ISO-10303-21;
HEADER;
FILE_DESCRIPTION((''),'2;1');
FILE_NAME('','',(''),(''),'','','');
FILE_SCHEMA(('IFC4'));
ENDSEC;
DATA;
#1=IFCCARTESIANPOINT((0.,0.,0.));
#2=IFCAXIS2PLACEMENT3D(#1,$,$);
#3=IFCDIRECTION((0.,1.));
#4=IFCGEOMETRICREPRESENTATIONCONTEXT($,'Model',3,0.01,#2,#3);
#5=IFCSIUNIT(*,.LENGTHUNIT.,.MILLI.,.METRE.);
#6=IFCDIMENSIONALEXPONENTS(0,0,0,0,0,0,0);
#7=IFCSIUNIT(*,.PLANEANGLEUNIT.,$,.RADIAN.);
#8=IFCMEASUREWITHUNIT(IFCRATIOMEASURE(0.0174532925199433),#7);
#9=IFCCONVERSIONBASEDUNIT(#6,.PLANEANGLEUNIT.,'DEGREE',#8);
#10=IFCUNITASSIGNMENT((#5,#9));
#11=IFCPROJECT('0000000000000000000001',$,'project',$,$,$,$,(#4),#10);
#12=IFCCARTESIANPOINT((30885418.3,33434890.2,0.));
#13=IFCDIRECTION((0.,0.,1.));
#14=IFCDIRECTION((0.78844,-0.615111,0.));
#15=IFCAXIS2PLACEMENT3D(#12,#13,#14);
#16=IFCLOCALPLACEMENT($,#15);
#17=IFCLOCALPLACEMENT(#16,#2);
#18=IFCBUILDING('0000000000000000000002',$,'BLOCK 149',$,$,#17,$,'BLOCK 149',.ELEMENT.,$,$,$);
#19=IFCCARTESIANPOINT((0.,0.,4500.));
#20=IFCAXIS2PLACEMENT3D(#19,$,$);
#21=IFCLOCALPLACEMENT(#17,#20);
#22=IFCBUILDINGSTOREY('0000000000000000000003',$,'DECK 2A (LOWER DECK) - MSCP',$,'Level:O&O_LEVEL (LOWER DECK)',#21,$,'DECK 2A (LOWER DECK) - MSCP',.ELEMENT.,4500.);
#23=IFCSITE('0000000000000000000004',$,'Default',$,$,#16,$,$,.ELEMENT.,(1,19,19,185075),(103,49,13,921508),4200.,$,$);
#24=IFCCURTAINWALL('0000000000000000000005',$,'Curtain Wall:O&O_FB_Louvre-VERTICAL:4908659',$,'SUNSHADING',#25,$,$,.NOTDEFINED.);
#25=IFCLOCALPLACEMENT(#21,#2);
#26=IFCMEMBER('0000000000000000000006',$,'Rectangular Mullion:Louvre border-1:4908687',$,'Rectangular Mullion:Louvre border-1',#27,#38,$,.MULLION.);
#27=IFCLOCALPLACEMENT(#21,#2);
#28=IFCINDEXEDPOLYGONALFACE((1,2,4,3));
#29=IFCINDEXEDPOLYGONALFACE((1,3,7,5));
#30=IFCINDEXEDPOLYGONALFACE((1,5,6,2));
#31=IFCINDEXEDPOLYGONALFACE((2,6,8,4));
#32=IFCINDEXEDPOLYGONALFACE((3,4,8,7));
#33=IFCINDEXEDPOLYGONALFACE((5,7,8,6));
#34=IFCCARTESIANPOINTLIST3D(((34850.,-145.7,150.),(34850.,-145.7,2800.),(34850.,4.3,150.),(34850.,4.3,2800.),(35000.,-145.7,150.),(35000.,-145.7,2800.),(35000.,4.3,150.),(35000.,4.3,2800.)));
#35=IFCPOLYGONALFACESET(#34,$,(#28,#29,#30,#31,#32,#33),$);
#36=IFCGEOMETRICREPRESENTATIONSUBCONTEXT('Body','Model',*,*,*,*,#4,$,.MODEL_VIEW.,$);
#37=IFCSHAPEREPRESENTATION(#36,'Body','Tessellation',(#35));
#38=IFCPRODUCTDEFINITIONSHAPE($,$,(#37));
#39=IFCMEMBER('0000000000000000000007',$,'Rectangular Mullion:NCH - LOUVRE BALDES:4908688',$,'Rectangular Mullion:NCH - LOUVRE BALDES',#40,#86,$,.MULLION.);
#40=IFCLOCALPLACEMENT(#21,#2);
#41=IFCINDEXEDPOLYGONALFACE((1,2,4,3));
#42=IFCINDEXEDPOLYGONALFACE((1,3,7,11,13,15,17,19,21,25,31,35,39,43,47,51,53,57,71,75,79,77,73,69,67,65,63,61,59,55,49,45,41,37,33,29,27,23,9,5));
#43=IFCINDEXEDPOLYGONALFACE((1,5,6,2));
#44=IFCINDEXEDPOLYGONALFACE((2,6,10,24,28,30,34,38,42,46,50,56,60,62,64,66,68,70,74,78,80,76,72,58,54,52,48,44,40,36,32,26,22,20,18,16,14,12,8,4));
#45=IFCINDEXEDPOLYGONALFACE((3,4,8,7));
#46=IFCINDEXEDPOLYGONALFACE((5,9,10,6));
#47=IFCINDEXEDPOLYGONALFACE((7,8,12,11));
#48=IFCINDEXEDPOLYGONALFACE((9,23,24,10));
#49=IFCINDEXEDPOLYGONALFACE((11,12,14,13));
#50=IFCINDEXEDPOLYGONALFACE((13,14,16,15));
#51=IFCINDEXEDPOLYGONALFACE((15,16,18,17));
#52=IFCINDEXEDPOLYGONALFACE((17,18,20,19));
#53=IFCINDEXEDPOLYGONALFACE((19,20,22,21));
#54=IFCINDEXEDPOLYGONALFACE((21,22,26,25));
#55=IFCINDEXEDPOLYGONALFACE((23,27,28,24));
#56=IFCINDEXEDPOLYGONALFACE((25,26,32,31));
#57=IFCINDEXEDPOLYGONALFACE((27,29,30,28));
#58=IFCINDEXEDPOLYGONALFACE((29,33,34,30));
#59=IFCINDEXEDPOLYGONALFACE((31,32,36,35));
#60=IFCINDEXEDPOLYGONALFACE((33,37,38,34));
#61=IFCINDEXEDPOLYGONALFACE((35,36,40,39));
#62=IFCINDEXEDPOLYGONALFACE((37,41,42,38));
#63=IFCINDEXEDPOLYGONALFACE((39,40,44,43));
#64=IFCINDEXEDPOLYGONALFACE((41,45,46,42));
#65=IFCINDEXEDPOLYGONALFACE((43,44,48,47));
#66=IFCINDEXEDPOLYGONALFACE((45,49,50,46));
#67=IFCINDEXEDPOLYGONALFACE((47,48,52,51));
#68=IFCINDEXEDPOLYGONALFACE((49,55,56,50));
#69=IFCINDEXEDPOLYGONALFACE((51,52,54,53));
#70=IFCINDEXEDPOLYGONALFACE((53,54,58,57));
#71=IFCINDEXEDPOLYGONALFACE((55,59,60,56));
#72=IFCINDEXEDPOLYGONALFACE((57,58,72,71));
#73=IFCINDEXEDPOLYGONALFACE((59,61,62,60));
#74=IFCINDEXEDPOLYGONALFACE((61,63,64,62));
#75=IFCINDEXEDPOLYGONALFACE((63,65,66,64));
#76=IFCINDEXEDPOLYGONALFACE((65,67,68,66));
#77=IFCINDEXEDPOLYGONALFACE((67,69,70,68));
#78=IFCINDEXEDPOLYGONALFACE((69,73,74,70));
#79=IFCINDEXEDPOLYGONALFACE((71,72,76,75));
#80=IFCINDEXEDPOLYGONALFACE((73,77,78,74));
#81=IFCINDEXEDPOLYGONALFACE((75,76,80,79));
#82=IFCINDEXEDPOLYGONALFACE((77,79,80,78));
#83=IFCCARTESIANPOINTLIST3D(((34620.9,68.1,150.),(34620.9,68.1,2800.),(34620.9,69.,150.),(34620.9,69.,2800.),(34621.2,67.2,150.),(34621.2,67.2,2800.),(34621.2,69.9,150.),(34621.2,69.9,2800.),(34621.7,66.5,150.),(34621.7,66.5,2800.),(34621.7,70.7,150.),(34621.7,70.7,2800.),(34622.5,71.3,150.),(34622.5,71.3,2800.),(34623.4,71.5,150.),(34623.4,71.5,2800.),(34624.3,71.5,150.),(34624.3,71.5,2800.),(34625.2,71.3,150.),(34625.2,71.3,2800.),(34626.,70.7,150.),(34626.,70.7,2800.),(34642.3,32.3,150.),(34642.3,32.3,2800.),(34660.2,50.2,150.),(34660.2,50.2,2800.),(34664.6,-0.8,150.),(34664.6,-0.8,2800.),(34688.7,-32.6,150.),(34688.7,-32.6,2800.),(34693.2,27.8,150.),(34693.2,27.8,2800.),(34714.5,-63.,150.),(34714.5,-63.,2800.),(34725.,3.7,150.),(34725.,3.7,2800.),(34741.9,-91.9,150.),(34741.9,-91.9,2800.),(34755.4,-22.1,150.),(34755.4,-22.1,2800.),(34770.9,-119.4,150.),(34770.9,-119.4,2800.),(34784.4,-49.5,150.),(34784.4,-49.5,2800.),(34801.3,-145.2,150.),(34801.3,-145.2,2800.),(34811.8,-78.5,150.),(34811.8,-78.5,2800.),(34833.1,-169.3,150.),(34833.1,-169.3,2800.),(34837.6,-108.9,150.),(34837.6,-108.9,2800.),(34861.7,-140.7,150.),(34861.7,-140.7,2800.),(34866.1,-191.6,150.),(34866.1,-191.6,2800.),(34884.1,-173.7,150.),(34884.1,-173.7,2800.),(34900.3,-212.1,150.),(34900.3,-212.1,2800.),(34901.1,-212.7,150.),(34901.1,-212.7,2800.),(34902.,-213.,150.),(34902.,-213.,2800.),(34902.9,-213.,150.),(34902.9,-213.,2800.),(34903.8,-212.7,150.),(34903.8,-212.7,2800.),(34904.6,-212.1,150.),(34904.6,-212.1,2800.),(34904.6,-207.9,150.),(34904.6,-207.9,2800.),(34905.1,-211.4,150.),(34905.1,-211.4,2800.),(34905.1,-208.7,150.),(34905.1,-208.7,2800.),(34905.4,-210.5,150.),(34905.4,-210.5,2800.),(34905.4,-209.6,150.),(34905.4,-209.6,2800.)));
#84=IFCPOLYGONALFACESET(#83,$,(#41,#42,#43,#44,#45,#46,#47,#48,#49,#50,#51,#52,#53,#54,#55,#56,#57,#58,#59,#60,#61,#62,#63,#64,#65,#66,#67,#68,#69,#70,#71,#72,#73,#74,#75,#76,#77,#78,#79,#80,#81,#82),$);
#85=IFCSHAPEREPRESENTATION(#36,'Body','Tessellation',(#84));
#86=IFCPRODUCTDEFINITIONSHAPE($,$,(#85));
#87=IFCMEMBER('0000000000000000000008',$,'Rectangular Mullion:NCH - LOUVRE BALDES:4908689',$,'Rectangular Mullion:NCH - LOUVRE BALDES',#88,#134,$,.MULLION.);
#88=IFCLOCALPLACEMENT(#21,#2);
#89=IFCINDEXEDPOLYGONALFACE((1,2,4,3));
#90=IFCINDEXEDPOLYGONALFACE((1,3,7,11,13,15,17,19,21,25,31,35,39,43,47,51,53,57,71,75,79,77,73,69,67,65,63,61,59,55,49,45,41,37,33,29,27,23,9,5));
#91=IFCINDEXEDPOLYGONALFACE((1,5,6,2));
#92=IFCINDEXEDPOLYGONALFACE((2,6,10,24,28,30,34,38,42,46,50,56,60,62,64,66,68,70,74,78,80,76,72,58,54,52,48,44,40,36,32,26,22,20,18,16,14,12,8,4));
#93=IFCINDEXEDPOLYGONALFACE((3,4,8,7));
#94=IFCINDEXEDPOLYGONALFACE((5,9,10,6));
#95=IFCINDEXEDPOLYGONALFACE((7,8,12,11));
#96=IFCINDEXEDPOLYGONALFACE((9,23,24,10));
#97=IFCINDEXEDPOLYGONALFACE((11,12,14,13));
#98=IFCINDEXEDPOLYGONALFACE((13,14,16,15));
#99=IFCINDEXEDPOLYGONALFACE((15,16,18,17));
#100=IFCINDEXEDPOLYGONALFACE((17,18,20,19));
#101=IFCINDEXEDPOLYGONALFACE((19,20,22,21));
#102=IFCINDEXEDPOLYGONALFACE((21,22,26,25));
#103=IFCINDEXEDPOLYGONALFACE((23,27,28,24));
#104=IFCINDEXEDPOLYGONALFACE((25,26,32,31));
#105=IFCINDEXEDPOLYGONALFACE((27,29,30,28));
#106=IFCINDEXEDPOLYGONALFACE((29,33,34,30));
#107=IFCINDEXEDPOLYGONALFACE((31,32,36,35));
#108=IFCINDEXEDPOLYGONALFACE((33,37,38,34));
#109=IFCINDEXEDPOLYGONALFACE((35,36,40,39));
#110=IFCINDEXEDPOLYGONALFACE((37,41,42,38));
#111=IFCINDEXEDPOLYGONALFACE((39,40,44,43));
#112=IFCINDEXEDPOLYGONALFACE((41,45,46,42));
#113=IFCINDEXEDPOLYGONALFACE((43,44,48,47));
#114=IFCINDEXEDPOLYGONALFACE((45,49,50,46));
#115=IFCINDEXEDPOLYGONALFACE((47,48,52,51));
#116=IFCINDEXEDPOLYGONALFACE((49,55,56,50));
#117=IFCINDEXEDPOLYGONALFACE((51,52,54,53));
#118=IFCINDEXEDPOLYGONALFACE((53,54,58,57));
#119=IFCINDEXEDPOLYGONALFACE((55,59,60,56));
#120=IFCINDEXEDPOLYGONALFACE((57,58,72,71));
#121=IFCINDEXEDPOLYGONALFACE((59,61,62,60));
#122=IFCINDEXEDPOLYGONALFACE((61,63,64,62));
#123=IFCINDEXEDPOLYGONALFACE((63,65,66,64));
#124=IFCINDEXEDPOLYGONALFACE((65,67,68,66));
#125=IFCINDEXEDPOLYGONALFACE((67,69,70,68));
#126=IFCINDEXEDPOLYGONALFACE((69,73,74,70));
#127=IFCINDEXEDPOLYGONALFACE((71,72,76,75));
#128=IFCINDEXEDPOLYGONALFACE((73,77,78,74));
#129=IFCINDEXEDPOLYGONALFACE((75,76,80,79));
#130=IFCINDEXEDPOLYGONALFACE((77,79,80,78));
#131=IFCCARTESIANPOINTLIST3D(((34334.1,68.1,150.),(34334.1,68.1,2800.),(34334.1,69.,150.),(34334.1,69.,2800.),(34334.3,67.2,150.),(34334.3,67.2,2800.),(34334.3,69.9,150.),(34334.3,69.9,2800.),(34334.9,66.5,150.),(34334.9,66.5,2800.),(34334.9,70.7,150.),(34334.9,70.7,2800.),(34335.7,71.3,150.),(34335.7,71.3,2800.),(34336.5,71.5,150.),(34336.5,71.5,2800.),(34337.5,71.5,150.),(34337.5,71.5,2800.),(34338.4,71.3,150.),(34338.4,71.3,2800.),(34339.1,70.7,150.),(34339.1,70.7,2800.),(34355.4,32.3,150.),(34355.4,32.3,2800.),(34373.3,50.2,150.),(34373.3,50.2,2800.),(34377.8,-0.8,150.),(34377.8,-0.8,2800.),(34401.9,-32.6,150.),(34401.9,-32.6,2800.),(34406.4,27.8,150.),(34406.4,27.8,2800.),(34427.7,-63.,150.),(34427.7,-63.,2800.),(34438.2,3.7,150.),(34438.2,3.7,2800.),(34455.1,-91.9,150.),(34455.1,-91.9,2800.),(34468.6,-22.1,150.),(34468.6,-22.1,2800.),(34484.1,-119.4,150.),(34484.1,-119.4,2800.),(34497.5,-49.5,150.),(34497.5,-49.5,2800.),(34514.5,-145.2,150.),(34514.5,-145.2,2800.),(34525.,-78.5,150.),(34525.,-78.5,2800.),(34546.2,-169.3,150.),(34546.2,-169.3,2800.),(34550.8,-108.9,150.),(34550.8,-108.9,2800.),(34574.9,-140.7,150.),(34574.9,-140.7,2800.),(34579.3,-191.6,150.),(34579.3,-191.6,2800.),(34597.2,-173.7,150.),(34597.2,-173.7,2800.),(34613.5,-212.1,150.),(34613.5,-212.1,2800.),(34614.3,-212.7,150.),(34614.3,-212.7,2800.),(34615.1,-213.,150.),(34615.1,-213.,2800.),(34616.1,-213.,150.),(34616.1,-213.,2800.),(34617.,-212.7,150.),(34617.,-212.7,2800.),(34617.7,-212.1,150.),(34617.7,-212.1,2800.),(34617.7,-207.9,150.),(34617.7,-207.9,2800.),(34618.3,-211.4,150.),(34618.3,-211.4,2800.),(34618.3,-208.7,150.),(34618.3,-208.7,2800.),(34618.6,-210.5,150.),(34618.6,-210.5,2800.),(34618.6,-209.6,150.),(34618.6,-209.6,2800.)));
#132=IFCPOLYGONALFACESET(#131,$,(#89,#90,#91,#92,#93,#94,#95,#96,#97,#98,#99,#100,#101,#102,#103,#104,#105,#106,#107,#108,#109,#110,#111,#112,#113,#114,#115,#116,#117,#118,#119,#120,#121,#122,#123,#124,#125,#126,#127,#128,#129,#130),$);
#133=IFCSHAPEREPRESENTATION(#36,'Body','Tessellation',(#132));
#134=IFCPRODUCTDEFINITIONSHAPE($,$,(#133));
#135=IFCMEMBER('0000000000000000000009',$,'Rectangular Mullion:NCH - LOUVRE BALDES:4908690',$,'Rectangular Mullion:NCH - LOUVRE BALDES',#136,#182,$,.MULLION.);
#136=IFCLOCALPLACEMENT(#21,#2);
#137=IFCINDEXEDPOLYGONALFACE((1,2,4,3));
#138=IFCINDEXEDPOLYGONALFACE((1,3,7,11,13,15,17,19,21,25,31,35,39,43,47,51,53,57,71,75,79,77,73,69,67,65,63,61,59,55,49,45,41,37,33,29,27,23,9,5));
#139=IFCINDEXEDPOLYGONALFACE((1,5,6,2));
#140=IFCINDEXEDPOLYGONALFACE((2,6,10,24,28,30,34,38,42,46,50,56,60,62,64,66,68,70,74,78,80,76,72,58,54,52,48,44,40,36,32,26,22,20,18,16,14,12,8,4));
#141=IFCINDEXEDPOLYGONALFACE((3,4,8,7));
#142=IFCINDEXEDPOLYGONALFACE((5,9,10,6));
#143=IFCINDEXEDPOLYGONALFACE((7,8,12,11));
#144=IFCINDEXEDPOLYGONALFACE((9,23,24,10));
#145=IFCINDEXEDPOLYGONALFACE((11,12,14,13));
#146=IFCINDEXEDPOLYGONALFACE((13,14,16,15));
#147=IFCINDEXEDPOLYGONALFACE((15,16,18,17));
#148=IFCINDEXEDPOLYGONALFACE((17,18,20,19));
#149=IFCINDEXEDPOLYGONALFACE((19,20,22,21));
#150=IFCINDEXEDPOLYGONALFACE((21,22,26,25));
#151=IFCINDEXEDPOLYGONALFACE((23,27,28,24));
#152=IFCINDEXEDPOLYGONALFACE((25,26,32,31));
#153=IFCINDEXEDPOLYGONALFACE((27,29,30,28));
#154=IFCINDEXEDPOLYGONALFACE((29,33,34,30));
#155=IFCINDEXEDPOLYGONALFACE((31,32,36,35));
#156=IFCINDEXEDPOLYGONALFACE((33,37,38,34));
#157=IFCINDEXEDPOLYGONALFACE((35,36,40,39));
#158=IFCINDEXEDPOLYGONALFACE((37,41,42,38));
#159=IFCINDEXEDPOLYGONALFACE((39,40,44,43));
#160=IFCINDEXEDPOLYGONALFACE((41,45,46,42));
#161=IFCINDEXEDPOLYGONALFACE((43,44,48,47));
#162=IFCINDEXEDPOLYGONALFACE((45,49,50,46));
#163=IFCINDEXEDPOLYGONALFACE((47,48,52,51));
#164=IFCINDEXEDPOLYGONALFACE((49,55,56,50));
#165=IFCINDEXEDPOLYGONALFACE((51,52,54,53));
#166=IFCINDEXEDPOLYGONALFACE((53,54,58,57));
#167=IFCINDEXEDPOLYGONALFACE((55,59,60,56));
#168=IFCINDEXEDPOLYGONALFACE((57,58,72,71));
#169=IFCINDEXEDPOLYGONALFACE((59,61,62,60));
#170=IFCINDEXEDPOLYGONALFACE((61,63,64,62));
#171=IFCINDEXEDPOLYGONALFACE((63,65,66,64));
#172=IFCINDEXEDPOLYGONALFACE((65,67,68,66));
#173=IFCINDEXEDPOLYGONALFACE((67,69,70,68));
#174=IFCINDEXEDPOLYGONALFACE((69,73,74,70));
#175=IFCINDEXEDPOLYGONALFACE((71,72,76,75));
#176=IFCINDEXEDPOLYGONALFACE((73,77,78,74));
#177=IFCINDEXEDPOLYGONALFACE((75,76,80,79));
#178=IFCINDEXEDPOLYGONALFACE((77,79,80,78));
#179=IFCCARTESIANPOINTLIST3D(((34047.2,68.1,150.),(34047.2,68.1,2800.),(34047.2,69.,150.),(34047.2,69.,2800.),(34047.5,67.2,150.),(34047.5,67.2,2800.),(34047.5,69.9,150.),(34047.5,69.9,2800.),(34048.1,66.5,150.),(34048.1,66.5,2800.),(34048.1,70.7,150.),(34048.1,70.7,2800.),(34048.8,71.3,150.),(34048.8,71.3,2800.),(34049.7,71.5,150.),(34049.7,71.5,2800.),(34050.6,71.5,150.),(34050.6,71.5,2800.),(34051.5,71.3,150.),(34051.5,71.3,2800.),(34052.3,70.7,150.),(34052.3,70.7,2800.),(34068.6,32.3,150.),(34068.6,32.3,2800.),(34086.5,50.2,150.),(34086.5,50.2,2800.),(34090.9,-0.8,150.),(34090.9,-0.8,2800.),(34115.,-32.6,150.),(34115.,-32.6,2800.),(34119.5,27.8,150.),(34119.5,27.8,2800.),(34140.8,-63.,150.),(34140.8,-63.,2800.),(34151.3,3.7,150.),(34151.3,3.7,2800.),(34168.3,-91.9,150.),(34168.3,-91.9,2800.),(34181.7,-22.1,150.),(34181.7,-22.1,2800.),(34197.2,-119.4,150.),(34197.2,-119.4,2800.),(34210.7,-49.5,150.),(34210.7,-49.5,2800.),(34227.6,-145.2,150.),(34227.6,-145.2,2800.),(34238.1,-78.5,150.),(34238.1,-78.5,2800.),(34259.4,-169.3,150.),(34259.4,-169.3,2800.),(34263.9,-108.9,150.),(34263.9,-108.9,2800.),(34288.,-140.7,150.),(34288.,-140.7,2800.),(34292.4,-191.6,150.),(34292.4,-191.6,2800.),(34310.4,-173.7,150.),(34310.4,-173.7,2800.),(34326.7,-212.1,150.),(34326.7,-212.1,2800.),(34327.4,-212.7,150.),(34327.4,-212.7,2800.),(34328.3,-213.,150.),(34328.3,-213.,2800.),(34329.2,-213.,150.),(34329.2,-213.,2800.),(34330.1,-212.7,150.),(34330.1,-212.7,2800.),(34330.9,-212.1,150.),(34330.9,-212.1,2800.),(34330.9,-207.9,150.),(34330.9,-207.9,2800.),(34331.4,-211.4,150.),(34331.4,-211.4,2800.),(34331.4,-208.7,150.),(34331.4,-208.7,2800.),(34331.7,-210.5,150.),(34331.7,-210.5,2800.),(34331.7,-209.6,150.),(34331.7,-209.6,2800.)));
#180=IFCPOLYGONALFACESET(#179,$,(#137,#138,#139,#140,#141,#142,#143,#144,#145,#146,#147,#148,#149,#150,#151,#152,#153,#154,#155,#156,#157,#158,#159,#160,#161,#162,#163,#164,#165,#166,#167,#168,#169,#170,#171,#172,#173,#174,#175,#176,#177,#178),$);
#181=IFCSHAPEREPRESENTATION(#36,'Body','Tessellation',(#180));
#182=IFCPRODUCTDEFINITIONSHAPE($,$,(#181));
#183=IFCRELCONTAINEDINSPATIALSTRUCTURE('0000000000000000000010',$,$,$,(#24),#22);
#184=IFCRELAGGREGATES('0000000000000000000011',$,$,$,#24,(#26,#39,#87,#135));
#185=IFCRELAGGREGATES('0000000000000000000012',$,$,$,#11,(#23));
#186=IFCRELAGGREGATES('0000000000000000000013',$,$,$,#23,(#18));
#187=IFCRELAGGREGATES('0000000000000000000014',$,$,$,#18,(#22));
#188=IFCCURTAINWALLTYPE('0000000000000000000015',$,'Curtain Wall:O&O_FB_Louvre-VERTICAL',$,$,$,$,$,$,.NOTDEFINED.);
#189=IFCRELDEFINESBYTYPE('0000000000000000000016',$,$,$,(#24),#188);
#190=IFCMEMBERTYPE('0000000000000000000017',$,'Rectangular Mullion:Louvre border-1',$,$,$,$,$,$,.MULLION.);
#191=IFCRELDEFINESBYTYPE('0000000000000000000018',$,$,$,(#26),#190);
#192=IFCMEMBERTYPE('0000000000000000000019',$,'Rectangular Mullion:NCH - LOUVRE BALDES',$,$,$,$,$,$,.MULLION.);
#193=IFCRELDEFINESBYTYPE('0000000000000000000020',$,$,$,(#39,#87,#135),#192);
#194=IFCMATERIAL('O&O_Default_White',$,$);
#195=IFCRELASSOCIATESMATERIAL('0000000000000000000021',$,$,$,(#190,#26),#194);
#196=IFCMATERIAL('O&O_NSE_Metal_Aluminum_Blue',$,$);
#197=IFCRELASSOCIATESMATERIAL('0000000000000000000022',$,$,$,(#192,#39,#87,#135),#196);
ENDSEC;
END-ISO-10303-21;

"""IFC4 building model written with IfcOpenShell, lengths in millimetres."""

from ifc_helpers import new_model, entity, si_unit, converted_unit, direction, frame, origin, place, context, subcontext, project, spatial, indexed_curve, outline, extrude, source, transform, mapped, material, type_object, type_shapes, element, aggregate, save


model = new_model("IFC4")

# Units and contexts
model_context = context("Model", 3, precision=0.01, world=origin(), true_north=direction((0.0, 1.0)))
body_context = subcontext(model_context, "Body", "Model", "MODEL_VIEW")
ifc_project = project(units=[si_unit("LENGTHUNIT", "METRE", prefix="MILLI"), converted_unit("PLANEANGLEUNIT", "DEGREE", entity("IfcRatioMeasure", 0.0174532925199433), si_unit("PLANEANGLEUNIT", "RADIAN"), dimensions=[0, 0, 0, 0, 0, 0, 0])], contexts=[model_context])

# Site, building, storey
site_placement = place(None, frame((30885418.3, 33434890.2, 0.0), z_axis=(0.0, 0.0, 1.0), x_axis=(0.78844, -0.615111, 0.0)))
site = spatial("IfcSite", under=ifc_project, at=site_placement, Name="Default", CompositionType="ELEMENT", RefLatitude=(1, 19, 19, 185075), RefLongitude=(103, 49, 13, 921508), RefElevation=4200.0)
building_placement = place(site_placement, origin())
building = spatial("IfcBuilding", under=site, at=building_placement, Name="BLOCK 149", LongName="BLOCK 149", CompositionType="ELEMENT")
storey_placement = place(building_placement, frame((0.0, 0.0, 4500.0)))
storey = spatial("IfcBuildingStorey", under=building, at=storey_placement, Name="DECK 2A (LOWER DECK) - MSCP", ObjectType="Level:O&O_LEVEL (LOWER DECK)", LongName="DECK 2A (LOWER DECK) - MSCP", CompositionType="ELEMENT", Elevation=4500.0)

# Curtain wall, members
curtain_wall_type = type_object("IfcCurtainWallType", Name="Curtain Wall:O&O_FB_Louvre-VERTICAL", PredefinedType="NOTDEFINED")
curtain_wall_placement = place(storey_placement, frame((0.0, 0.0, -4500.0)))
curtain_wall = element("IfcCurtainWall", 1, at=curtain_wall_placement, inside=storey, type_object=curtain_wall_type, Name="Curtain Wall:O&O_FB_Louvre-VERTICAL:4908659", ObjectType="SUNSHADING", PredefinedType="NOTDEFINED")
ifc_material_1 = material(Name="O&O_Default_White")
placement = place(building_placement, origin())
member_type_1 = type_object("IfcMemberType", Name="Rectangular Mullion:Louvre border-1", PredefinedType="MULLION", material=ifc_material_1)
shared_shape_1 = source(origin(), body_context, "Body", "SweptSolid", [
    extrude(outline(indexed_curve([(-75.0, -75.0), (75.0, -75.0), (75.0, 75.0), (-75.0, 75.0), (-75.0, -75.0)], self_intersect=False)), frame((-75.0, 0.0, -2650.0), z_axis=(0.0, 0.0, 1.0), x_axis=(0.0, -1.0, 0.0)), (0.0, 0.0, 1.0), 2650.0),
])
type_shapes(member_type_1, [shared_shape_1])
member_1_placement = place(placement, frame((35000.0, -70.7, 7300.0)))
member_1 = element("IfcMember", 2, at=member_1_placement, type_object=member_type_1, material=ifc_material_1, Name="Rectangular Mullion:Louvre border-1:4908687", ObjectType="Rectangular Mullion:Louvre border-1", PredefinedType="MULLION", context=body_context, shape_type="MappedRepresentation", body=[
    mapped(shared_shape_1, transform((0.0, 0.0, 0.0), scale=1.0)),
])
ifc_material_2 = material(Name="O&O_NSE_Metal_Aluminum_Blue")
member_type_2 = type_object("IfcMemberType", Name="Rectangular Mullion:NCH - LOUVRE BALDES", PredefinedType="MULLION", material=ifc_material_2)
shared_shape_2 = source(origin(), body_context, "Body", "SweptSolid", [
    extrude(outline(indexed_curve([(55.9, -188.9), (54.8, -149.1), (51.6, -109.3), (46.1, -69.8), (38.6, -30.6), (28.9, 8.1), (17.1, 46.2), (3.3, 83.6), (-12.6, 120.2), (-30.4, 155.9), (-50.1, 190.5), (-50.5, 191.4), (-51.1, 192.1), (-52.0, 192.5), (-52.9, 192.7), (-53.8, 192.6), (-54.7, 192.2), (-55.4, 191.6), (-55.8, 190.8), (-56.0, 189.9), (-55.9, 188.9), (-54.8, 149.1), (-51.6, 109.3), (-46.1, 69.8), (-38.6, 30.6), (-28.9, -8.1), (-17.1, -46.2), (-3.3, -83.6), (12.6, -120.2), (30.4, -155.9), (50.1, -190.5), (50.5, -191.4), (51.1, -192.1), (52.0, -192.5), (52.9, -192.7), (53.8, -192.6), (54.7, -192.2), (55.4, -191.6), (55.8, -190.8), (56.0, -189.9), (55.9, -188.9)], self_intersect=False)), frame((0.0, 0.0, -2650.0), z_axis=(0.0, 0.0, 1.0), x_axis=(0.490779, -0.871284, 0.0)), (0.0, 0.0, 1.0), 2650.0),
])
type_shapes(member_type_2, [shared_shape_2])
member_2_placement = place(placement, frame((34763.2, -70.7, 4650.0), z_axis=(0.0, 0.0, -1.0), x_axis=(-1.0, 0.0, 0.0)))
member_2 = element("IfcMember", 3, at=member_2_placement, type_object=member_type_2, material=ifc_material_2, Name="Rectangular Mullion:NCH - LOUVRE BALDES:4908688", ObjectType="Rectangular Mullion:NCH - LOUVRE BALDES", PredefinedType="MULLION", context=body_context, shape_type="MappedRepresentation", body=[
    mapped(shared_shape_2, transform((0.0, 0.0, 0.0), scale=1.0)),
])
member_3_placement = place(placement, frame((34476.3, -70.7, 4650.0), z_axis=(0.0, 0.0, -1.0), x_axis=(-1.0, 0.0, 0.0)))
member_3 = element("IfcMember", 4, at=member_3_placement, type_object=member_type_2, material=ifc_material_2, Name="Rectangular Mullion:NCH - LOUVRE BALDES:4908689", ObjectType="Rectangular Mullion:NCH - LOUVRE BALDES", PredefinedType="MULLION", context=body_context, shape_type="MappedRepresentation", body=[
    mapped(shared_shape_2, transform((0.0, 0.0, 0.0), scale=1.0)),
])
member_4_placement = place(placement, frame((34189.5, -70.7, 4650.0), z_axis=(0.0, 0.0, -1.0), x_axis=(-1.0, 0.0, 0.0)))
member_4 = element("IfcMember", 5, at=member_4_placement, type_object=member_type_2, material=ifc_material_2, Name="Rectangular Mullion:NCH - LOUVRE BALDES:4908690", ObjectType="Rectangular Mullion:NCH - LOUVRE BALDES", PredefinedType="MULLION", context=body_context, shape_type="MappedRepresentation", body=[
    mapped(shared_shape_2, transform((0.0, 0.0, 0.0), scale=1.0)),
])
aggregate(curtain_wall, [member_1, member_2, member_3, member_4])

save(model, "model.ifc")
